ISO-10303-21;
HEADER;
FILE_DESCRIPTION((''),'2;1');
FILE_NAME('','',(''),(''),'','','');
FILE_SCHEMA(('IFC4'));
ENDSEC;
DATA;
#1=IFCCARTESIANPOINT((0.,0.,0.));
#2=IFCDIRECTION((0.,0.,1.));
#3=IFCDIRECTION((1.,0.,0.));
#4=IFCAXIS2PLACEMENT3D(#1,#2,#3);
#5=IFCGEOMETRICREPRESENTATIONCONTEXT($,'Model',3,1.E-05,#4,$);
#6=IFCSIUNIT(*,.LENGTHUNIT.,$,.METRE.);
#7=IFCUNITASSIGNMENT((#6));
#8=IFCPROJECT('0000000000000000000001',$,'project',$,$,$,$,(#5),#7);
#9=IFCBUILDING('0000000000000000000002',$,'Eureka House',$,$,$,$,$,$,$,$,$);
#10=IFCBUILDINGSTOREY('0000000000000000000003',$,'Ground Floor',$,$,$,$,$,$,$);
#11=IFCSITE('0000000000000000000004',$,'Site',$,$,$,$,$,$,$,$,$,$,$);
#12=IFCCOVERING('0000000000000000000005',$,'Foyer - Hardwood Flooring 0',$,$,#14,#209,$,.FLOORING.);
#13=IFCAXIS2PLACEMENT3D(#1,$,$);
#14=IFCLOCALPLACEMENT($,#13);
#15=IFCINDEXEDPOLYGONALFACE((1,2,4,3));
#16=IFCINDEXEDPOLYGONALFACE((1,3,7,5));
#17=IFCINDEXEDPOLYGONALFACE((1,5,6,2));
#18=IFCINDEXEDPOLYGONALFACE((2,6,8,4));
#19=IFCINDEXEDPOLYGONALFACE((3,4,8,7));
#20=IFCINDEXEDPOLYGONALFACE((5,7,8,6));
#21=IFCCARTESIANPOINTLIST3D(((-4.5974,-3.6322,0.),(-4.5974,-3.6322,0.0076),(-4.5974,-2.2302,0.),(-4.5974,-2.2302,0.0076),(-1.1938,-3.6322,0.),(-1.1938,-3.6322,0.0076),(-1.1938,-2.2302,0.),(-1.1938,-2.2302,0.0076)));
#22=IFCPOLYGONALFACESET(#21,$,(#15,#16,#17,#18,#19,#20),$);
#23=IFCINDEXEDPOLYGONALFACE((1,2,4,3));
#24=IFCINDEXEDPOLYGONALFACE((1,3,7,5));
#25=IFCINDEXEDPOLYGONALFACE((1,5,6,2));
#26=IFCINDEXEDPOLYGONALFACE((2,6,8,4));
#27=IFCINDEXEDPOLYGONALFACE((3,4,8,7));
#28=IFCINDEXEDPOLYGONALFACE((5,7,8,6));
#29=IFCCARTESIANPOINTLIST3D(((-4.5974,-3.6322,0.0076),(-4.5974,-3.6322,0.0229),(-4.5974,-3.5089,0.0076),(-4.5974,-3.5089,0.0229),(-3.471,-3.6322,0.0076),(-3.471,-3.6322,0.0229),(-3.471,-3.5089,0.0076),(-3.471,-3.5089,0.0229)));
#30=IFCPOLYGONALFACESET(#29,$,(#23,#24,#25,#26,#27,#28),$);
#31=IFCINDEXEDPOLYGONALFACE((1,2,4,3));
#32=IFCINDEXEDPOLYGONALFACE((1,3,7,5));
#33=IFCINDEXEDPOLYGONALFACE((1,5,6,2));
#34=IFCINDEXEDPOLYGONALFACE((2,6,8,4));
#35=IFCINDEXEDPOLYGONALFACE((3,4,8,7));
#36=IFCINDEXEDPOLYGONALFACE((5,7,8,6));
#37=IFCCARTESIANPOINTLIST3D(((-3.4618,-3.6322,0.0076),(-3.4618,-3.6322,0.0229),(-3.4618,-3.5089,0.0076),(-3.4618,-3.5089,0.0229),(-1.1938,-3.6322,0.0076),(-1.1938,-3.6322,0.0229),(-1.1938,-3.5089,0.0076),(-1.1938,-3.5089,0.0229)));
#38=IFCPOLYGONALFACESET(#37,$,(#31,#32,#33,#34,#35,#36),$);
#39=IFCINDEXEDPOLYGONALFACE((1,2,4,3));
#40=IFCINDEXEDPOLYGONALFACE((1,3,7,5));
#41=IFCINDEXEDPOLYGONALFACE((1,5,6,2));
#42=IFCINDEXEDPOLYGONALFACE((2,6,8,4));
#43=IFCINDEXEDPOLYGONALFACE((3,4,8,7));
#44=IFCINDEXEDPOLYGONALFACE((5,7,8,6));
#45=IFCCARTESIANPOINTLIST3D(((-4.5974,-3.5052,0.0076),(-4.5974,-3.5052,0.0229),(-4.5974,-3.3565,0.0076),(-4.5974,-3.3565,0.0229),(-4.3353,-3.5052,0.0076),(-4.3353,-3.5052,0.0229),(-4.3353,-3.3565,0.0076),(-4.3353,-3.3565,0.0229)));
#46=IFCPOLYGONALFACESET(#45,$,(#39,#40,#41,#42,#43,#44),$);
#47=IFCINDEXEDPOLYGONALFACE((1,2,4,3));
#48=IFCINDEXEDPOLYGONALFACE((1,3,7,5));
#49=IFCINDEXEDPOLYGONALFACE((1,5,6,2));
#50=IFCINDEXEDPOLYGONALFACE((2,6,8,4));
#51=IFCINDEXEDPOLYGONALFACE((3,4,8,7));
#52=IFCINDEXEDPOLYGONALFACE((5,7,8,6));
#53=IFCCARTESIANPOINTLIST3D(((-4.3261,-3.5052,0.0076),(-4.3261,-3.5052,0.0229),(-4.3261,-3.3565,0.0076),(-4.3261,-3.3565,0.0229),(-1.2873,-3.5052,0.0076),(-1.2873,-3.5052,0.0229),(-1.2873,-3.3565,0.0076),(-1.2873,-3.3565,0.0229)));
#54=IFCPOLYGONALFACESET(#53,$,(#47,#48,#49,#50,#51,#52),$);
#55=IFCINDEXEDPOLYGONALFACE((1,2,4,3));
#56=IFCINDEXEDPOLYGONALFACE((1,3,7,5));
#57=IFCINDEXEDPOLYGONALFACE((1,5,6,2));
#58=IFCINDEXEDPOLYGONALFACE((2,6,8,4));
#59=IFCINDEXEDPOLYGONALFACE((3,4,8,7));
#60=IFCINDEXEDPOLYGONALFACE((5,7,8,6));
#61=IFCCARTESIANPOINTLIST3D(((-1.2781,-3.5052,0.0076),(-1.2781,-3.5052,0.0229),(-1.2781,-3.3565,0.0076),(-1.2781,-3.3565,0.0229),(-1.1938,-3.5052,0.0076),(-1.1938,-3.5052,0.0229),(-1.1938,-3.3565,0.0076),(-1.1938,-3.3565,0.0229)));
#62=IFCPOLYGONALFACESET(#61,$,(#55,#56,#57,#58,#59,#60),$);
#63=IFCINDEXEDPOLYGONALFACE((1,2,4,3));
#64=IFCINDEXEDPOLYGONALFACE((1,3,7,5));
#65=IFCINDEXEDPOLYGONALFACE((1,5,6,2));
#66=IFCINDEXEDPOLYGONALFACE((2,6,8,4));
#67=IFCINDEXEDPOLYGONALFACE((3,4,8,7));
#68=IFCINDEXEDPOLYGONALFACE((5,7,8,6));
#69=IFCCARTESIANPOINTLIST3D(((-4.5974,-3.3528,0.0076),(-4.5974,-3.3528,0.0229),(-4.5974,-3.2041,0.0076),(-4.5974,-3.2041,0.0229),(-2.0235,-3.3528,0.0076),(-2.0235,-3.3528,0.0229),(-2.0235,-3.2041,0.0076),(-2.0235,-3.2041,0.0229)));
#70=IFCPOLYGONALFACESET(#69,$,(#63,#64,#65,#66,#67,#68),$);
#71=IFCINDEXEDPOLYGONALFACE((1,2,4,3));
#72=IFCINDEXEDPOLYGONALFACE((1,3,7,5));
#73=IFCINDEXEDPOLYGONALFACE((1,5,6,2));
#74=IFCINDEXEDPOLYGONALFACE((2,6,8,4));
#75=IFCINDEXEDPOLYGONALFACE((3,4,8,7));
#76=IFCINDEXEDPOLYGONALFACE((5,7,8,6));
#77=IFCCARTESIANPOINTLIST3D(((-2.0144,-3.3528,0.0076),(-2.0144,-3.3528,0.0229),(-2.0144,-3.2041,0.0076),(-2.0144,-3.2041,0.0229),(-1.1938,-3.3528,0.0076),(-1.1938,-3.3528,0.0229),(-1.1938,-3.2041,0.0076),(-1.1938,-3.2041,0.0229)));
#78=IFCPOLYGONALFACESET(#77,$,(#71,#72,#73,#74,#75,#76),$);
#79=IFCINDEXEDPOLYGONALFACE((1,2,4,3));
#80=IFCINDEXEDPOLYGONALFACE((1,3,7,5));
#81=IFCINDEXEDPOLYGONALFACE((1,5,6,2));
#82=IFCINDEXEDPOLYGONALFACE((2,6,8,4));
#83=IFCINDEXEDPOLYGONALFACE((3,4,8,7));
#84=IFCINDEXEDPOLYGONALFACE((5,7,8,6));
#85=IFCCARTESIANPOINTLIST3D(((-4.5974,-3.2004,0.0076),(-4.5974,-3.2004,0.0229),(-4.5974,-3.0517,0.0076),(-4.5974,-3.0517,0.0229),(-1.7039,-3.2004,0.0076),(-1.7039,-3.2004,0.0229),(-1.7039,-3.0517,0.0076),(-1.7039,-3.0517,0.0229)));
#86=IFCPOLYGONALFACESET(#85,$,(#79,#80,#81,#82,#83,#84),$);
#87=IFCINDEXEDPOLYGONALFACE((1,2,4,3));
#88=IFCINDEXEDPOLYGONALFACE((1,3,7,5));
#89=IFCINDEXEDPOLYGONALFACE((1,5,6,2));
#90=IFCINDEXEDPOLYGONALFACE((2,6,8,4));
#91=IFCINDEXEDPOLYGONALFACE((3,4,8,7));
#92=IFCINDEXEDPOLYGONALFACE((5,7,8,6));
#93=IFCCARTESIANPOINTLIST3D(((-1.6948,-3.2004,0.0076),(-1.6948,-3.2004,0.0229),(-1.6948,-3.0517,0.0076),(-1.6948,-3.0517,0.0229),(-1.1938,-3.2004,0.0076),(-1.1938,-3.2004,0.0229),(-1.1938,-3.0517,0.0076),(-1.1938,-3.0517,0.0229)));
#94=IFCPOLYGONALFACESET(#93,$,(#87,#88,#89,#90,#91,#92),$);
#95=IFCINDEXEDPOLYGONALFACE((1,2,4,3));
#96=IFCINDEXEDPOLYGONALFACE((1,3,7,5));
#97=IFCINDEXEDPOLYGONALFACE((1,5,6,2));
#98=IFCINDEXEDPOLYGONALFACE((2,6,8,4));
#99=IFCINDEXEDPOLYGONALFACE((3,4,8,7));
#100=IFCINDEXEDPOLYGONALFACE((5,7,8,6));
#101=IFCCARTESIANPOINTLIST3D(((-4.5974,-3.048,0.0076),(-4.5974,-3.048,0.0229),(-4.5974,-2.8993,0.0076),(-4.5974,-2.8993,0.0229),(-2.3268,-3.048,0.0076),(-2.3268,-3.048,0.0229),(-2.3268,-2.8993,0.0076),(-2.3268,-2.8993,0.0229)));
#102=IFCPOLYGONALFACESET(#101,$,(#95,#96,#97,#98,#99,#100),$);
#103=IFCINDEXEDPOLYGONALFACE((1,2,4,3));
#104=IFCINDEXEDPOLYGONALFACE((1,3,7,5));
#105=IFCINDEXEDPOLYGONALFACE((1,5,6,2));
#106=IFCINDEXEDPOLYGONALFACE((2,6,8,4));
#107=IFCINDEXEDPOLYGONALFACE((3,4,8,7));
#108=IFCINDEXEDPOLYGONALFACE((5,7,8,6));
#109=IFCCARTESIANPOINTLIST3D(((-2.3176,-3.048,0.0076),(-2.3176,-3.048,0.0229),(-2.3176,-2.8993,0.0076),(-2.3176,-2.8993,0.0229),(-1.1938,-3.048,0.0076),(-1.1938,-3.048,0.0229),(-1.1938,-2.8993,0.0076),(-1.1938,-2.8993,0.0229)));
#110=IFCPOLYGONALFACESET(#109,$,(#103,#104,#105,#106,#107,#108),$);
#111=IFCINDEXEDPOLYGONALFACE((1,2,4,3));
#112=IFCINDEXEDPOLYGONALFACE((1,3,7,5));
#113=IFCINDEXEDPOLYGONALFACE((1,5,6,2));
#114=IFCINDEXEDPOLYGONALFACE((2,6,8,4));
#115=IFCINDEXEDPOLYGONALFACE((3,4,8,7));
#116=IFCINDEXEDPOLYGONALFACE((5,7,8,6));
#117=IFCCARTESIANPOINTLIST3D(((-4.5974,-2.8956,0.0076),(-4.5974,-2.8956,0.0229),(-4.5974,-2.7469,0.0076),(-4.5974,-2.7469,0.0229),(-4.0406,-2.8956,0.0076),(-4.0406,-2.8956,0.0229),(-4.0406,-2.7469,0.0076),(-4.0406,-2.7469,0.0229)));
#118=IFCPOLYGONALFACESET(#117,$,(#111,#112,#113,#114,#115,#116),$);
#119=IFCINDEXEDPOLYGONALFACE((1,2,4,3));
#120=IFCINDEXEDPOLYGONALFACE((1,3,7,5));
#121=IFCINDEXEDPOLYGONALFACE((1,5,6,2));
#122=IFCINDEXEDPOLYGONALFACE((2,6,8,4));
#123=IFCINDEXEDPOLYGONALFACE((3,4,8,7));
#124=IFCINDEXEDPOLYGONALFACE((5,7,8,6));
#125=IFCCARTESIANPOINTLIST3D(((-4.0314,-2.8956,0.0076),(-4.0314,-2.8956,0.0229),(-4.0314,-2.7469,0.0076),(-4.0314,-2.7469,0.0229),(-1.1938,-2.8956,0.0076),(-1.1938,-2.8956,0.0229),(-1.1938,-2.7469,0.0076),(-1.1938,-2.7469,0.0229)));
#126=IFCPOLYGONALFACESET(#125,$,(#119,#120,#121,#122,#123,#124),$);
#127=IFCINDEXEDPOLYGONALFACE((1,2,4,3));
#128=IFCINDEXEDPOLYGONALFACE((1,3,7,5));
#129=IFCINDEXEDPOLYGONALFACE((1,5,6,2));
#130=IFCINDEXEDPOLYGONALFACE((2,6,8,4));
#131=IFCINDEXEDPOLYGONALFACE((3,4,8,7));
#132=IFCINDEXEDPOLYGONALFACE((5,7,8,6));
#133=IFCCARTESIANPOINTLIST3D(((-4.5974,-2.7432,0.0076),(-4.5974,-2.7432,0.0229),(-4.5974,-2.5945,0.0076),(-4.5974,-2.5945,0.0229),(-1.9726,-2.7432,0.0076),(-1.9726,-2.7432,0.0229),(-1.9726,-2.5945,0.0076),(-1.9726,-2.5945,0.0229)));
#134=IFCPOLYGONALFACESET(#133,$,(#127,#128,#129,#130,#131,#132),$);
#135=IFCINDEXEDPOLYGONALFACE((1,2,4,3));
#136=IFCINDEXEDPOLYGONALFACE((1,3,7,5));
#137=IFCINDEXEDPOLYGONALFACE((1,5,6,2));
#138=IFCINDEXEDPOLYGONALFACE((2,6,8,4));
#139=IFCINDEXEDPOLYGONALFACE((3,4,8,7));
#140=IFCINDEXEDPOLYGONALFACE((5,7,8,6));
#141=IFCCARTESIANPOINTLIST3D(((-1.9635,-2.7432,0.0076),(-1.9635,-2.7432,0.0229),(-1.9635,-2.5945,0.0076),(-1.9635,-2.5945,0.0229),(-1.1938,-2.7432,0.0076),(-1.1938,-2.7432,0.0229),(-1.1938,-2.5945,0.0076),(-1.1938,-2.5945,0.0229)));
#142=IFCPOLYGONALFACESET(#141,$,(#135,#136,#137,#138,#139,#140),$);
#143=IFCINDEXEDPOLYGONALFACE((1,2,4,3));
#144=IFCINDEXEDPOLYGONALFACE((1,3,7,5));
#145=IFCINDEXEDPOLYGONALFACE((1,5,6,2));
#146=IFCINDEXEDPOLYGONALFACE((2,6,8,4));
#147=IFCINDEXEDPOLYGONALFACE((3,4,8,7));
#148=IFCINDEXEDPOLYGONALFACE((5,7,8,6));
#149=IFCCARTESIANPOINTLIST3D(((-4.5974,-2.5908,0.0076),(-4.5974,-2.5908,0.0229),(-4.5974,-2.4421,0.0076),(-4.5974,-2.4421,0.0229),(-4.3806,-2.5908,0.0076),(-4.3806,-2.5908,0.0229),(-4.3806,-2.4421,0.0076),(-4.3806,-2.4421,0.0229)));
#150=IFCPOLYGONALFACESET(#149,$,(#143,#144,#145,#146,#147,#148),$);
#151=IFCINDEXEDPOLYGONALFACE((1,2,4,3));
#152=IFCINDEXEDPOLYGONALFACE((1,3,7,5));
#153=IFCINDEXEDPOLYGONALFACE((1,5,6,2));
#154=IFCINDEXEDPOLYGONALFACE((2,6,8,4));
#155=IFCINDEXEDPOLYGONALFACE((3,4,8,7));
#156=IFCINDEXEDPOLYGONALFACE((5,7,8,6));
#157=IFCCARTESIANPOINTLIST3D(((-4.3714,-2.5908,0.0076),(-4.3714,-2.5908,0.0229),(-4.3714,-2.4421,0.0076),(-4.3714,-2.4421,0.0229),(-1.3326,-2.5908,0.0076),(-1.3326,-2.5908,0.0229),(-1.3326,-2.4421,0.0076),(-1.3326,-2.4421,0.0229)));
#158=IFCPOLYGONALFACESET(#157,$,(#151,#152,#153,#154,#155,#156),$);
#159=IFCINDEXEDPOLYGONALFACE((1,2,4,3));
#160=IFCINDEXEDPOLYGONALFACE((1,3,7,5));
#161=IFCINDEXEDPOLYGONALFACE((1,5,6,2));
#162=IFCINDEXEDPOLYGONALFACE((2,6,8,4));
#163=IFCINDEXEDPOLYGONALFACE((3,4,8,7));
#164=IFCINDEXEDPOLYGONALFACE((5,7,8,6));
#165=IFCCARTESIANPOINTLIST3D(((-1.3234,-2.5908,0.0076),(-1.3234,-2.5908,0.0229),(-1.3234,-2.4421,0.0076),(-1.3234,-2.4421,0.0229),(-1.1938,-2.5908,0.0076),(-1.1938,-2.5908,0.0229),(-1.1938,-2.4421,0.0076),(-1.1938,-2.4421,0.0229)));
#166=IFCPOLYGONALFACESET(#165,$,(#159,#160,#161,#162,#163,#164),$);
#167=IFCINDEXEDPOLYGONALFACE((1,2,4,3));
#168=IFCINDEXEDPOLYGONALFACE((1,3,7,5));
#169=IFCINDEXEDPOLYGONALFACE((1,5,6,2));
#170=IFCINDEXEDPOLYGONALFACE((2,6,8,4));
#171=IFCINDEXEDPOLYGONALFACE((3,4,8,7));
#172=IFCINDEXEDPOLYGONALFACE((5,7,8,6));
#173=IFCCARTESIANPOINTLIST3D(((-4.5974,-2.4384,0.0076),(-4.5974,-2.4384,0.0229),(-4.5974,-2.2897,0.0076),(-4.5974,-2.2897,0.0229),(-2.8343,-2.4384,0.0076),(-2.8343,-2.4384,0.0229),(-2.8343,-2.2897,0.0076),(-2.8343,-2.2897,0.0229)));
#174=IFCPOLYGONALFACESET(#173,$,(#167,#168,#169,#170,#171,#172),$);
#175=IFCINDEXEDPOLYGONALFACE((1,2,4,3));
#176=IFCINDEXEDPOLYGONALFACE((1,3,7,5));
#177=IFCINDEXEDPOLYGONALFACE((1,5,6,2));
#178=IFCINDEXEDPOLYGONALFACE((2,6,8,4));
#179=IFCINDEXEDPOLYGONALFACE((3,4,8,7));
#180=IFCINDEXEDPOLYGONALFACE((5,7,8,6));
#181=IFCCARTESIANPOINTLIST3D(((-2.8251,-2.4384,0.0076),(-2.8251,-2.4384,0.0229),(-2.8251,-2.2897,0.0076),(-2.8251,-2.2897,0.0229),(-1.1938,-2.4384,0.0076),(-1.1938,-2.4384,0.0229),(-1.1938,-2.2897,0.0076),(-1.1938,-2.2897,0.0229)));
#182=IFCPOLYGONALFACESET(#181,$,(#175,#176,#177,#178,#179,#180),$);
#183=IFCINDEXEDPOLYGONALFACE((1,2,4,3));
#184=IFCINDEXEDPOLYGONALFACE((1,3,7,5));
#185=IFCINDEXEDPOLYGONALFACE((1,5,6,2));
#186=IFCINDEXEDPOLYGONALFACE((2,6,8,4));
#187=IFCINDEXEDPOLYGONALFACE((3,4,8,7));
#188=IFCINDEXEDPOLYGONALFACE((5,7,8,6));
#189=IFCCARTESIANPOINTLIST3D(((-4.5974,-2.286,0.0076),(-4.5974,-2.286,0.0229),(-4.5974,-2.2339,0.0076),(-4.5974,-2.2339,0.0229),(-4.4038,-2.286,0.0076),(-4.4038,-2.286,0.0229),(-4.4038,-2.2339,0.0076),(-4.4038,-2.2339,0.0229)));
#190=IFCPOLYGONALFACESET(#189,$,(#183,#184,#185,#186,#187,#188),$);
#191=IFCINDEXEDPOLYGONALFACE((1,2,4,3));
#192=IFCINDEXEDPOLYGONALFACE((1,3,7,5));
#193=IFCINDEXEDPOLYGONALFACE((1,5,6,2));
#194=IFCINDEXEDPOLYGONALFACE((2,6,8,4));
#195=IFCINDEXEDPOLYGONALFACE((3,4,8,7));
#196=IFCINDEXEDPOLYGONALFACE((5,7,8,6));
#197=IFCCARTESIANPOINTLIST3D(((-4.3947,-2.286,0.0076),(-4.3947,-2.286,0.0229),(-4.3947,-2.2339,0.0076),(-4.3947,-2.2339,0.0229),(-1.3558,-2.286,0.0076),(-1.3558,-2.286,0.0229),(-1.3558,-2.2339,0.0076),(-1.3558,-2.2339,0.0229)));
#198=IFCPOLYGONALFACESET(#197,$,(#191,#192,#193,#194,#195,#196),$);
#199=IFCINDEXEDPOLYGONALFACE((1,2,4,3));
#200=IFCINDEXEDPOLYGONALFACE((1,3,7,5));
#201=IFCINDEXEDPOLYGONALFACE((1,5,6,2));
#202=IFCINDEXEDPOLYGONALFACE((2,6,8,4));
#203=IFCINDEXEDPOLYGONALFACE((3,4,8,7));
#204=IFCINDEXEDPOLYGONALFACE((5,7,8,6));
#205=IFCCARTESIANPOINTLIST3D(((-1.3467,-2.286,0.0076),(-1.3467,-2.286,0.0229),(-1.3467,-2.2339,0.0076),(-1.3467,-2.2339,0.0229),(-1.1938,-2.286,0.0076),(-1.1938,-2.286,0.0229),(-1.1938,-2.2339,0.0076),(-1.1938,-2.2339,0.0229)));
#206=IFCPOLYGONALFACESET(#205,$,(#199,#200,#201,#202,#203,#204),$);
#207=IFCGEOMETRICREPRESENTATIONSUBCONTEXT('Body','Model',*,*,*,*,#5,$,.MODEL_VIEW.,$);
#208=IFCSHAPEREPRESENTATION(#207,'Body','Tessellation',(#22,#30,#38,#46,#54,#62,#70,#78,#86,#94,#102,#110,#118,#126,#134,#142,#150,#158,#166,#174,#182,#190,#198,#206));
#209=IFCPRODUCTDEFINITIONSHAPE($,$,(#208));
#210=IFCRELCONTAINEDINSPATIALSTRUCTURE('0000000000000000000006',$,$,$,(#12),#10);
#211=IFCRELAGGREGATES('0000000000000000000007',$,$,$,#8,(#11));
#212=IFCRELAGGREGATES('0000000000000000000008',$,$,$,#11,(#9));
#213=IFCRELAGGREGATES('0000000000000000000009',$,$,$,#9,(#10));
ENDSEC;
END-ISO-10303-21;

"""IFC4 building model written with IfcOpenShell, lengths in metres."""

from ifc_helpers import new_model, si_unit, frame, origin_with_axes, origin_2d, place, context, subcontext, project, spatial, rectangle, extrude, element, save


model = new_model("IFC4")

# Units and contexts
model_context = context("Model", 3, precision=1e-05, world=origin_with_axes())
body_context = subcontext(model_context, "Body", "Model", "MODEL_VIEW")
ifc_project = project(units=[si_unit("LENGTHUNIT", "METRE")], contexts=[model_context])

# Site, building, storey
site = spatial("IfcSite", under=ifc_project, Name="Site")
building = spatial("IfcBuilding", under=site, Name="Eureka House")
storey = spatial("IfcBuildingStorey", under=building, Name="Ground Floor")

# Covering
covering_1_placement = place(None, origin_with_axes())
element("IfcCovering", 1, at=covering_1_placement, inside=storey, Name="Foyer - Hardwood Flooring 0", PredefinedType="FLOORING", context=body_context, shape_type="SweptSolid", body=[
    extrude(rectangle(XDim=3.4036, YDim=1.402, at=origin_2d()), frame((-2.8956, -2.9312, 0.0)), (0.0, 0.0, 1.0), 0.0076),
    extrude(rectangle(XDim=1.1264, YDim=0.1234, at=origin_2d()), frame((-4.0342, -3.5705, 0.0076)), (0.0, 0.0, 1.0), 0.0152),
    extrude(rectangle(XDim=2.268, YDim=0.1234, at=origin_2d()), frame((-2.3278, -3.5705, 0.0076)), (0.0, 0.0, 1.0), 0.0152),
    extrude(rectangle(XDim=0.2621, YDim=0.1487, at=origin_2d()), frame((-4.4663, -3.4308, 0.0076)), (0.0, 0.0, 1.0), 0.0152),
    extrude(rectangle(XDim=3.0389, YDim=0.1487, at=origin_2d()), frame((-2.8067, -3.4308, 0.0076)), (0.0, 0.0, 1.0), 0.0152),
    extrude(rectangle(XDim=0.0843, YDim=0.1487, at=origin_2d()), frame((-1.236, -3.4308, 0.0076)), (0.0, 0.0, 1.0), 0.0152),
    extrude(rectangle(XDim=2.5739, YDim=0.1487, at=origin_2d()), frame((-3.3104, -3.2784, 0.0076)), (0.0, 0.0, 1.0), 0.0152),
    extrude(rectangle(XDim=0.8205, YDim=0.1487, at=origin_2d()), frame((-1.6041, -3.2784, 0.0076)), (0.0, 0.0, 1.0), 0.0152),
    extrude(rectangle(XDim=2.8935, YDim=0.1487, at=origin_2d()), frame((-3.1507, -3.126, 0.0076)), (0.0, 0.0, 1.0), 0.0152),
    extrude(rectangle(XDim=0.501, YDim=0.1487, at=origin_2d()), frame((-1.4443, -3.126, 0.0076)), (0.0, 0.0, 1.0), 0.0152),
    extrude(rectangle(XDim=2.2706, YDim=0.1487, at=origin_2d()), frame((-3.4621, -2.9736, 0.0076)), (0.0, 0.0, 1.0), 0.0152),
    extrude(rectangle(XDim=1.1238, YDim=0.1487, at=origin_2d()), frame((-1.7557, -2.9736, 0.0076)), (0.0, 0.0, 1.0), 0.0152),
    extrude(rectangle(XDim=0.5568, YDim=0.1487, at=origin_2d()), frame((-4.319, -2.8212, 0.0076)), (0.0, 0.0, 1.0), 0.0152),
    extrude(rectangle(XDim=2.8376, YDim=0.1487, at=origin_2d()), frame((-2.6126, -2.8212, 0.0076)), (0.0, 0.0, 1.0), 0.0152),
    extrude(rectangle(XDim=2.6248, YDim=0.1487, at=origin_2d()), frame((-3.285, -2.6688, 0.0076)), (0.0, 0.0, 1.0), 0.0152),
    extrude(rectangle(XDim=0.7697, YDim=0.1487, at=origin_2d()), frame((-1.5786, -2.6688, 0.0076)), (0.0, 0.0, 1.0), 0.0152),
    extrude(rectangle(XDim=0.2168, YDim=0.1487, at=origin_2d()), frame((-4.489, -2.5164, 0.0076)), (0.0, 0.0, 1.0), 0.0152),
    extrude(rectangle(XDim=3.0389, YDim=0.1487, at=origin_2d()), frame((-2.852, -2.5164, 0.0076)), (0.0, 0.0, 1.0), 0.0152),
    extrude(rectangle(XDim=0.1296, YDim=0.1487, at=origin_2d()), frame((-1.2586, -2.5164, 0.0076)), (0.0, 0.0, 1.0), 0.0152),
    extrude(rectangle(XDim=1.7631, YDim=0.1487, at=origin_2d()), frame((-3.7158, -2.364, 0.0076)), (0.0, 0.0, 1.0), 0.0152),
    extrude(rectangle(XDim=1.6313, YDim=0.1487, at=origin_2d()), frame((-2.0095, -2.364, 0.0076)), (0.0, 0.0, 1.0), 0.0152),
    extrude(rectangle(XDim=0.1936, YDim=0.0521, at=origin_2d()), frame((-4.5006, -2.2599, 0.0076)), (0.0, 0.0, 1.0), 0.0152),
    extrude(rectangle(XDim=3.0389, YDim=0.0521, at=origin_2d()), frame((-2.8752, -2.2599, 0.0076)), (0.0, 0.0, 1.0), 0.0152),
    extrude(rectangle(XDim=0.1528, YDim=0.0521, at=origin_2d()), frame((-1.2702, -2.2599, 0.0076)), (0.0, 0.0, 1.0), 0.0152),
])

save(model, "model.ifc")
